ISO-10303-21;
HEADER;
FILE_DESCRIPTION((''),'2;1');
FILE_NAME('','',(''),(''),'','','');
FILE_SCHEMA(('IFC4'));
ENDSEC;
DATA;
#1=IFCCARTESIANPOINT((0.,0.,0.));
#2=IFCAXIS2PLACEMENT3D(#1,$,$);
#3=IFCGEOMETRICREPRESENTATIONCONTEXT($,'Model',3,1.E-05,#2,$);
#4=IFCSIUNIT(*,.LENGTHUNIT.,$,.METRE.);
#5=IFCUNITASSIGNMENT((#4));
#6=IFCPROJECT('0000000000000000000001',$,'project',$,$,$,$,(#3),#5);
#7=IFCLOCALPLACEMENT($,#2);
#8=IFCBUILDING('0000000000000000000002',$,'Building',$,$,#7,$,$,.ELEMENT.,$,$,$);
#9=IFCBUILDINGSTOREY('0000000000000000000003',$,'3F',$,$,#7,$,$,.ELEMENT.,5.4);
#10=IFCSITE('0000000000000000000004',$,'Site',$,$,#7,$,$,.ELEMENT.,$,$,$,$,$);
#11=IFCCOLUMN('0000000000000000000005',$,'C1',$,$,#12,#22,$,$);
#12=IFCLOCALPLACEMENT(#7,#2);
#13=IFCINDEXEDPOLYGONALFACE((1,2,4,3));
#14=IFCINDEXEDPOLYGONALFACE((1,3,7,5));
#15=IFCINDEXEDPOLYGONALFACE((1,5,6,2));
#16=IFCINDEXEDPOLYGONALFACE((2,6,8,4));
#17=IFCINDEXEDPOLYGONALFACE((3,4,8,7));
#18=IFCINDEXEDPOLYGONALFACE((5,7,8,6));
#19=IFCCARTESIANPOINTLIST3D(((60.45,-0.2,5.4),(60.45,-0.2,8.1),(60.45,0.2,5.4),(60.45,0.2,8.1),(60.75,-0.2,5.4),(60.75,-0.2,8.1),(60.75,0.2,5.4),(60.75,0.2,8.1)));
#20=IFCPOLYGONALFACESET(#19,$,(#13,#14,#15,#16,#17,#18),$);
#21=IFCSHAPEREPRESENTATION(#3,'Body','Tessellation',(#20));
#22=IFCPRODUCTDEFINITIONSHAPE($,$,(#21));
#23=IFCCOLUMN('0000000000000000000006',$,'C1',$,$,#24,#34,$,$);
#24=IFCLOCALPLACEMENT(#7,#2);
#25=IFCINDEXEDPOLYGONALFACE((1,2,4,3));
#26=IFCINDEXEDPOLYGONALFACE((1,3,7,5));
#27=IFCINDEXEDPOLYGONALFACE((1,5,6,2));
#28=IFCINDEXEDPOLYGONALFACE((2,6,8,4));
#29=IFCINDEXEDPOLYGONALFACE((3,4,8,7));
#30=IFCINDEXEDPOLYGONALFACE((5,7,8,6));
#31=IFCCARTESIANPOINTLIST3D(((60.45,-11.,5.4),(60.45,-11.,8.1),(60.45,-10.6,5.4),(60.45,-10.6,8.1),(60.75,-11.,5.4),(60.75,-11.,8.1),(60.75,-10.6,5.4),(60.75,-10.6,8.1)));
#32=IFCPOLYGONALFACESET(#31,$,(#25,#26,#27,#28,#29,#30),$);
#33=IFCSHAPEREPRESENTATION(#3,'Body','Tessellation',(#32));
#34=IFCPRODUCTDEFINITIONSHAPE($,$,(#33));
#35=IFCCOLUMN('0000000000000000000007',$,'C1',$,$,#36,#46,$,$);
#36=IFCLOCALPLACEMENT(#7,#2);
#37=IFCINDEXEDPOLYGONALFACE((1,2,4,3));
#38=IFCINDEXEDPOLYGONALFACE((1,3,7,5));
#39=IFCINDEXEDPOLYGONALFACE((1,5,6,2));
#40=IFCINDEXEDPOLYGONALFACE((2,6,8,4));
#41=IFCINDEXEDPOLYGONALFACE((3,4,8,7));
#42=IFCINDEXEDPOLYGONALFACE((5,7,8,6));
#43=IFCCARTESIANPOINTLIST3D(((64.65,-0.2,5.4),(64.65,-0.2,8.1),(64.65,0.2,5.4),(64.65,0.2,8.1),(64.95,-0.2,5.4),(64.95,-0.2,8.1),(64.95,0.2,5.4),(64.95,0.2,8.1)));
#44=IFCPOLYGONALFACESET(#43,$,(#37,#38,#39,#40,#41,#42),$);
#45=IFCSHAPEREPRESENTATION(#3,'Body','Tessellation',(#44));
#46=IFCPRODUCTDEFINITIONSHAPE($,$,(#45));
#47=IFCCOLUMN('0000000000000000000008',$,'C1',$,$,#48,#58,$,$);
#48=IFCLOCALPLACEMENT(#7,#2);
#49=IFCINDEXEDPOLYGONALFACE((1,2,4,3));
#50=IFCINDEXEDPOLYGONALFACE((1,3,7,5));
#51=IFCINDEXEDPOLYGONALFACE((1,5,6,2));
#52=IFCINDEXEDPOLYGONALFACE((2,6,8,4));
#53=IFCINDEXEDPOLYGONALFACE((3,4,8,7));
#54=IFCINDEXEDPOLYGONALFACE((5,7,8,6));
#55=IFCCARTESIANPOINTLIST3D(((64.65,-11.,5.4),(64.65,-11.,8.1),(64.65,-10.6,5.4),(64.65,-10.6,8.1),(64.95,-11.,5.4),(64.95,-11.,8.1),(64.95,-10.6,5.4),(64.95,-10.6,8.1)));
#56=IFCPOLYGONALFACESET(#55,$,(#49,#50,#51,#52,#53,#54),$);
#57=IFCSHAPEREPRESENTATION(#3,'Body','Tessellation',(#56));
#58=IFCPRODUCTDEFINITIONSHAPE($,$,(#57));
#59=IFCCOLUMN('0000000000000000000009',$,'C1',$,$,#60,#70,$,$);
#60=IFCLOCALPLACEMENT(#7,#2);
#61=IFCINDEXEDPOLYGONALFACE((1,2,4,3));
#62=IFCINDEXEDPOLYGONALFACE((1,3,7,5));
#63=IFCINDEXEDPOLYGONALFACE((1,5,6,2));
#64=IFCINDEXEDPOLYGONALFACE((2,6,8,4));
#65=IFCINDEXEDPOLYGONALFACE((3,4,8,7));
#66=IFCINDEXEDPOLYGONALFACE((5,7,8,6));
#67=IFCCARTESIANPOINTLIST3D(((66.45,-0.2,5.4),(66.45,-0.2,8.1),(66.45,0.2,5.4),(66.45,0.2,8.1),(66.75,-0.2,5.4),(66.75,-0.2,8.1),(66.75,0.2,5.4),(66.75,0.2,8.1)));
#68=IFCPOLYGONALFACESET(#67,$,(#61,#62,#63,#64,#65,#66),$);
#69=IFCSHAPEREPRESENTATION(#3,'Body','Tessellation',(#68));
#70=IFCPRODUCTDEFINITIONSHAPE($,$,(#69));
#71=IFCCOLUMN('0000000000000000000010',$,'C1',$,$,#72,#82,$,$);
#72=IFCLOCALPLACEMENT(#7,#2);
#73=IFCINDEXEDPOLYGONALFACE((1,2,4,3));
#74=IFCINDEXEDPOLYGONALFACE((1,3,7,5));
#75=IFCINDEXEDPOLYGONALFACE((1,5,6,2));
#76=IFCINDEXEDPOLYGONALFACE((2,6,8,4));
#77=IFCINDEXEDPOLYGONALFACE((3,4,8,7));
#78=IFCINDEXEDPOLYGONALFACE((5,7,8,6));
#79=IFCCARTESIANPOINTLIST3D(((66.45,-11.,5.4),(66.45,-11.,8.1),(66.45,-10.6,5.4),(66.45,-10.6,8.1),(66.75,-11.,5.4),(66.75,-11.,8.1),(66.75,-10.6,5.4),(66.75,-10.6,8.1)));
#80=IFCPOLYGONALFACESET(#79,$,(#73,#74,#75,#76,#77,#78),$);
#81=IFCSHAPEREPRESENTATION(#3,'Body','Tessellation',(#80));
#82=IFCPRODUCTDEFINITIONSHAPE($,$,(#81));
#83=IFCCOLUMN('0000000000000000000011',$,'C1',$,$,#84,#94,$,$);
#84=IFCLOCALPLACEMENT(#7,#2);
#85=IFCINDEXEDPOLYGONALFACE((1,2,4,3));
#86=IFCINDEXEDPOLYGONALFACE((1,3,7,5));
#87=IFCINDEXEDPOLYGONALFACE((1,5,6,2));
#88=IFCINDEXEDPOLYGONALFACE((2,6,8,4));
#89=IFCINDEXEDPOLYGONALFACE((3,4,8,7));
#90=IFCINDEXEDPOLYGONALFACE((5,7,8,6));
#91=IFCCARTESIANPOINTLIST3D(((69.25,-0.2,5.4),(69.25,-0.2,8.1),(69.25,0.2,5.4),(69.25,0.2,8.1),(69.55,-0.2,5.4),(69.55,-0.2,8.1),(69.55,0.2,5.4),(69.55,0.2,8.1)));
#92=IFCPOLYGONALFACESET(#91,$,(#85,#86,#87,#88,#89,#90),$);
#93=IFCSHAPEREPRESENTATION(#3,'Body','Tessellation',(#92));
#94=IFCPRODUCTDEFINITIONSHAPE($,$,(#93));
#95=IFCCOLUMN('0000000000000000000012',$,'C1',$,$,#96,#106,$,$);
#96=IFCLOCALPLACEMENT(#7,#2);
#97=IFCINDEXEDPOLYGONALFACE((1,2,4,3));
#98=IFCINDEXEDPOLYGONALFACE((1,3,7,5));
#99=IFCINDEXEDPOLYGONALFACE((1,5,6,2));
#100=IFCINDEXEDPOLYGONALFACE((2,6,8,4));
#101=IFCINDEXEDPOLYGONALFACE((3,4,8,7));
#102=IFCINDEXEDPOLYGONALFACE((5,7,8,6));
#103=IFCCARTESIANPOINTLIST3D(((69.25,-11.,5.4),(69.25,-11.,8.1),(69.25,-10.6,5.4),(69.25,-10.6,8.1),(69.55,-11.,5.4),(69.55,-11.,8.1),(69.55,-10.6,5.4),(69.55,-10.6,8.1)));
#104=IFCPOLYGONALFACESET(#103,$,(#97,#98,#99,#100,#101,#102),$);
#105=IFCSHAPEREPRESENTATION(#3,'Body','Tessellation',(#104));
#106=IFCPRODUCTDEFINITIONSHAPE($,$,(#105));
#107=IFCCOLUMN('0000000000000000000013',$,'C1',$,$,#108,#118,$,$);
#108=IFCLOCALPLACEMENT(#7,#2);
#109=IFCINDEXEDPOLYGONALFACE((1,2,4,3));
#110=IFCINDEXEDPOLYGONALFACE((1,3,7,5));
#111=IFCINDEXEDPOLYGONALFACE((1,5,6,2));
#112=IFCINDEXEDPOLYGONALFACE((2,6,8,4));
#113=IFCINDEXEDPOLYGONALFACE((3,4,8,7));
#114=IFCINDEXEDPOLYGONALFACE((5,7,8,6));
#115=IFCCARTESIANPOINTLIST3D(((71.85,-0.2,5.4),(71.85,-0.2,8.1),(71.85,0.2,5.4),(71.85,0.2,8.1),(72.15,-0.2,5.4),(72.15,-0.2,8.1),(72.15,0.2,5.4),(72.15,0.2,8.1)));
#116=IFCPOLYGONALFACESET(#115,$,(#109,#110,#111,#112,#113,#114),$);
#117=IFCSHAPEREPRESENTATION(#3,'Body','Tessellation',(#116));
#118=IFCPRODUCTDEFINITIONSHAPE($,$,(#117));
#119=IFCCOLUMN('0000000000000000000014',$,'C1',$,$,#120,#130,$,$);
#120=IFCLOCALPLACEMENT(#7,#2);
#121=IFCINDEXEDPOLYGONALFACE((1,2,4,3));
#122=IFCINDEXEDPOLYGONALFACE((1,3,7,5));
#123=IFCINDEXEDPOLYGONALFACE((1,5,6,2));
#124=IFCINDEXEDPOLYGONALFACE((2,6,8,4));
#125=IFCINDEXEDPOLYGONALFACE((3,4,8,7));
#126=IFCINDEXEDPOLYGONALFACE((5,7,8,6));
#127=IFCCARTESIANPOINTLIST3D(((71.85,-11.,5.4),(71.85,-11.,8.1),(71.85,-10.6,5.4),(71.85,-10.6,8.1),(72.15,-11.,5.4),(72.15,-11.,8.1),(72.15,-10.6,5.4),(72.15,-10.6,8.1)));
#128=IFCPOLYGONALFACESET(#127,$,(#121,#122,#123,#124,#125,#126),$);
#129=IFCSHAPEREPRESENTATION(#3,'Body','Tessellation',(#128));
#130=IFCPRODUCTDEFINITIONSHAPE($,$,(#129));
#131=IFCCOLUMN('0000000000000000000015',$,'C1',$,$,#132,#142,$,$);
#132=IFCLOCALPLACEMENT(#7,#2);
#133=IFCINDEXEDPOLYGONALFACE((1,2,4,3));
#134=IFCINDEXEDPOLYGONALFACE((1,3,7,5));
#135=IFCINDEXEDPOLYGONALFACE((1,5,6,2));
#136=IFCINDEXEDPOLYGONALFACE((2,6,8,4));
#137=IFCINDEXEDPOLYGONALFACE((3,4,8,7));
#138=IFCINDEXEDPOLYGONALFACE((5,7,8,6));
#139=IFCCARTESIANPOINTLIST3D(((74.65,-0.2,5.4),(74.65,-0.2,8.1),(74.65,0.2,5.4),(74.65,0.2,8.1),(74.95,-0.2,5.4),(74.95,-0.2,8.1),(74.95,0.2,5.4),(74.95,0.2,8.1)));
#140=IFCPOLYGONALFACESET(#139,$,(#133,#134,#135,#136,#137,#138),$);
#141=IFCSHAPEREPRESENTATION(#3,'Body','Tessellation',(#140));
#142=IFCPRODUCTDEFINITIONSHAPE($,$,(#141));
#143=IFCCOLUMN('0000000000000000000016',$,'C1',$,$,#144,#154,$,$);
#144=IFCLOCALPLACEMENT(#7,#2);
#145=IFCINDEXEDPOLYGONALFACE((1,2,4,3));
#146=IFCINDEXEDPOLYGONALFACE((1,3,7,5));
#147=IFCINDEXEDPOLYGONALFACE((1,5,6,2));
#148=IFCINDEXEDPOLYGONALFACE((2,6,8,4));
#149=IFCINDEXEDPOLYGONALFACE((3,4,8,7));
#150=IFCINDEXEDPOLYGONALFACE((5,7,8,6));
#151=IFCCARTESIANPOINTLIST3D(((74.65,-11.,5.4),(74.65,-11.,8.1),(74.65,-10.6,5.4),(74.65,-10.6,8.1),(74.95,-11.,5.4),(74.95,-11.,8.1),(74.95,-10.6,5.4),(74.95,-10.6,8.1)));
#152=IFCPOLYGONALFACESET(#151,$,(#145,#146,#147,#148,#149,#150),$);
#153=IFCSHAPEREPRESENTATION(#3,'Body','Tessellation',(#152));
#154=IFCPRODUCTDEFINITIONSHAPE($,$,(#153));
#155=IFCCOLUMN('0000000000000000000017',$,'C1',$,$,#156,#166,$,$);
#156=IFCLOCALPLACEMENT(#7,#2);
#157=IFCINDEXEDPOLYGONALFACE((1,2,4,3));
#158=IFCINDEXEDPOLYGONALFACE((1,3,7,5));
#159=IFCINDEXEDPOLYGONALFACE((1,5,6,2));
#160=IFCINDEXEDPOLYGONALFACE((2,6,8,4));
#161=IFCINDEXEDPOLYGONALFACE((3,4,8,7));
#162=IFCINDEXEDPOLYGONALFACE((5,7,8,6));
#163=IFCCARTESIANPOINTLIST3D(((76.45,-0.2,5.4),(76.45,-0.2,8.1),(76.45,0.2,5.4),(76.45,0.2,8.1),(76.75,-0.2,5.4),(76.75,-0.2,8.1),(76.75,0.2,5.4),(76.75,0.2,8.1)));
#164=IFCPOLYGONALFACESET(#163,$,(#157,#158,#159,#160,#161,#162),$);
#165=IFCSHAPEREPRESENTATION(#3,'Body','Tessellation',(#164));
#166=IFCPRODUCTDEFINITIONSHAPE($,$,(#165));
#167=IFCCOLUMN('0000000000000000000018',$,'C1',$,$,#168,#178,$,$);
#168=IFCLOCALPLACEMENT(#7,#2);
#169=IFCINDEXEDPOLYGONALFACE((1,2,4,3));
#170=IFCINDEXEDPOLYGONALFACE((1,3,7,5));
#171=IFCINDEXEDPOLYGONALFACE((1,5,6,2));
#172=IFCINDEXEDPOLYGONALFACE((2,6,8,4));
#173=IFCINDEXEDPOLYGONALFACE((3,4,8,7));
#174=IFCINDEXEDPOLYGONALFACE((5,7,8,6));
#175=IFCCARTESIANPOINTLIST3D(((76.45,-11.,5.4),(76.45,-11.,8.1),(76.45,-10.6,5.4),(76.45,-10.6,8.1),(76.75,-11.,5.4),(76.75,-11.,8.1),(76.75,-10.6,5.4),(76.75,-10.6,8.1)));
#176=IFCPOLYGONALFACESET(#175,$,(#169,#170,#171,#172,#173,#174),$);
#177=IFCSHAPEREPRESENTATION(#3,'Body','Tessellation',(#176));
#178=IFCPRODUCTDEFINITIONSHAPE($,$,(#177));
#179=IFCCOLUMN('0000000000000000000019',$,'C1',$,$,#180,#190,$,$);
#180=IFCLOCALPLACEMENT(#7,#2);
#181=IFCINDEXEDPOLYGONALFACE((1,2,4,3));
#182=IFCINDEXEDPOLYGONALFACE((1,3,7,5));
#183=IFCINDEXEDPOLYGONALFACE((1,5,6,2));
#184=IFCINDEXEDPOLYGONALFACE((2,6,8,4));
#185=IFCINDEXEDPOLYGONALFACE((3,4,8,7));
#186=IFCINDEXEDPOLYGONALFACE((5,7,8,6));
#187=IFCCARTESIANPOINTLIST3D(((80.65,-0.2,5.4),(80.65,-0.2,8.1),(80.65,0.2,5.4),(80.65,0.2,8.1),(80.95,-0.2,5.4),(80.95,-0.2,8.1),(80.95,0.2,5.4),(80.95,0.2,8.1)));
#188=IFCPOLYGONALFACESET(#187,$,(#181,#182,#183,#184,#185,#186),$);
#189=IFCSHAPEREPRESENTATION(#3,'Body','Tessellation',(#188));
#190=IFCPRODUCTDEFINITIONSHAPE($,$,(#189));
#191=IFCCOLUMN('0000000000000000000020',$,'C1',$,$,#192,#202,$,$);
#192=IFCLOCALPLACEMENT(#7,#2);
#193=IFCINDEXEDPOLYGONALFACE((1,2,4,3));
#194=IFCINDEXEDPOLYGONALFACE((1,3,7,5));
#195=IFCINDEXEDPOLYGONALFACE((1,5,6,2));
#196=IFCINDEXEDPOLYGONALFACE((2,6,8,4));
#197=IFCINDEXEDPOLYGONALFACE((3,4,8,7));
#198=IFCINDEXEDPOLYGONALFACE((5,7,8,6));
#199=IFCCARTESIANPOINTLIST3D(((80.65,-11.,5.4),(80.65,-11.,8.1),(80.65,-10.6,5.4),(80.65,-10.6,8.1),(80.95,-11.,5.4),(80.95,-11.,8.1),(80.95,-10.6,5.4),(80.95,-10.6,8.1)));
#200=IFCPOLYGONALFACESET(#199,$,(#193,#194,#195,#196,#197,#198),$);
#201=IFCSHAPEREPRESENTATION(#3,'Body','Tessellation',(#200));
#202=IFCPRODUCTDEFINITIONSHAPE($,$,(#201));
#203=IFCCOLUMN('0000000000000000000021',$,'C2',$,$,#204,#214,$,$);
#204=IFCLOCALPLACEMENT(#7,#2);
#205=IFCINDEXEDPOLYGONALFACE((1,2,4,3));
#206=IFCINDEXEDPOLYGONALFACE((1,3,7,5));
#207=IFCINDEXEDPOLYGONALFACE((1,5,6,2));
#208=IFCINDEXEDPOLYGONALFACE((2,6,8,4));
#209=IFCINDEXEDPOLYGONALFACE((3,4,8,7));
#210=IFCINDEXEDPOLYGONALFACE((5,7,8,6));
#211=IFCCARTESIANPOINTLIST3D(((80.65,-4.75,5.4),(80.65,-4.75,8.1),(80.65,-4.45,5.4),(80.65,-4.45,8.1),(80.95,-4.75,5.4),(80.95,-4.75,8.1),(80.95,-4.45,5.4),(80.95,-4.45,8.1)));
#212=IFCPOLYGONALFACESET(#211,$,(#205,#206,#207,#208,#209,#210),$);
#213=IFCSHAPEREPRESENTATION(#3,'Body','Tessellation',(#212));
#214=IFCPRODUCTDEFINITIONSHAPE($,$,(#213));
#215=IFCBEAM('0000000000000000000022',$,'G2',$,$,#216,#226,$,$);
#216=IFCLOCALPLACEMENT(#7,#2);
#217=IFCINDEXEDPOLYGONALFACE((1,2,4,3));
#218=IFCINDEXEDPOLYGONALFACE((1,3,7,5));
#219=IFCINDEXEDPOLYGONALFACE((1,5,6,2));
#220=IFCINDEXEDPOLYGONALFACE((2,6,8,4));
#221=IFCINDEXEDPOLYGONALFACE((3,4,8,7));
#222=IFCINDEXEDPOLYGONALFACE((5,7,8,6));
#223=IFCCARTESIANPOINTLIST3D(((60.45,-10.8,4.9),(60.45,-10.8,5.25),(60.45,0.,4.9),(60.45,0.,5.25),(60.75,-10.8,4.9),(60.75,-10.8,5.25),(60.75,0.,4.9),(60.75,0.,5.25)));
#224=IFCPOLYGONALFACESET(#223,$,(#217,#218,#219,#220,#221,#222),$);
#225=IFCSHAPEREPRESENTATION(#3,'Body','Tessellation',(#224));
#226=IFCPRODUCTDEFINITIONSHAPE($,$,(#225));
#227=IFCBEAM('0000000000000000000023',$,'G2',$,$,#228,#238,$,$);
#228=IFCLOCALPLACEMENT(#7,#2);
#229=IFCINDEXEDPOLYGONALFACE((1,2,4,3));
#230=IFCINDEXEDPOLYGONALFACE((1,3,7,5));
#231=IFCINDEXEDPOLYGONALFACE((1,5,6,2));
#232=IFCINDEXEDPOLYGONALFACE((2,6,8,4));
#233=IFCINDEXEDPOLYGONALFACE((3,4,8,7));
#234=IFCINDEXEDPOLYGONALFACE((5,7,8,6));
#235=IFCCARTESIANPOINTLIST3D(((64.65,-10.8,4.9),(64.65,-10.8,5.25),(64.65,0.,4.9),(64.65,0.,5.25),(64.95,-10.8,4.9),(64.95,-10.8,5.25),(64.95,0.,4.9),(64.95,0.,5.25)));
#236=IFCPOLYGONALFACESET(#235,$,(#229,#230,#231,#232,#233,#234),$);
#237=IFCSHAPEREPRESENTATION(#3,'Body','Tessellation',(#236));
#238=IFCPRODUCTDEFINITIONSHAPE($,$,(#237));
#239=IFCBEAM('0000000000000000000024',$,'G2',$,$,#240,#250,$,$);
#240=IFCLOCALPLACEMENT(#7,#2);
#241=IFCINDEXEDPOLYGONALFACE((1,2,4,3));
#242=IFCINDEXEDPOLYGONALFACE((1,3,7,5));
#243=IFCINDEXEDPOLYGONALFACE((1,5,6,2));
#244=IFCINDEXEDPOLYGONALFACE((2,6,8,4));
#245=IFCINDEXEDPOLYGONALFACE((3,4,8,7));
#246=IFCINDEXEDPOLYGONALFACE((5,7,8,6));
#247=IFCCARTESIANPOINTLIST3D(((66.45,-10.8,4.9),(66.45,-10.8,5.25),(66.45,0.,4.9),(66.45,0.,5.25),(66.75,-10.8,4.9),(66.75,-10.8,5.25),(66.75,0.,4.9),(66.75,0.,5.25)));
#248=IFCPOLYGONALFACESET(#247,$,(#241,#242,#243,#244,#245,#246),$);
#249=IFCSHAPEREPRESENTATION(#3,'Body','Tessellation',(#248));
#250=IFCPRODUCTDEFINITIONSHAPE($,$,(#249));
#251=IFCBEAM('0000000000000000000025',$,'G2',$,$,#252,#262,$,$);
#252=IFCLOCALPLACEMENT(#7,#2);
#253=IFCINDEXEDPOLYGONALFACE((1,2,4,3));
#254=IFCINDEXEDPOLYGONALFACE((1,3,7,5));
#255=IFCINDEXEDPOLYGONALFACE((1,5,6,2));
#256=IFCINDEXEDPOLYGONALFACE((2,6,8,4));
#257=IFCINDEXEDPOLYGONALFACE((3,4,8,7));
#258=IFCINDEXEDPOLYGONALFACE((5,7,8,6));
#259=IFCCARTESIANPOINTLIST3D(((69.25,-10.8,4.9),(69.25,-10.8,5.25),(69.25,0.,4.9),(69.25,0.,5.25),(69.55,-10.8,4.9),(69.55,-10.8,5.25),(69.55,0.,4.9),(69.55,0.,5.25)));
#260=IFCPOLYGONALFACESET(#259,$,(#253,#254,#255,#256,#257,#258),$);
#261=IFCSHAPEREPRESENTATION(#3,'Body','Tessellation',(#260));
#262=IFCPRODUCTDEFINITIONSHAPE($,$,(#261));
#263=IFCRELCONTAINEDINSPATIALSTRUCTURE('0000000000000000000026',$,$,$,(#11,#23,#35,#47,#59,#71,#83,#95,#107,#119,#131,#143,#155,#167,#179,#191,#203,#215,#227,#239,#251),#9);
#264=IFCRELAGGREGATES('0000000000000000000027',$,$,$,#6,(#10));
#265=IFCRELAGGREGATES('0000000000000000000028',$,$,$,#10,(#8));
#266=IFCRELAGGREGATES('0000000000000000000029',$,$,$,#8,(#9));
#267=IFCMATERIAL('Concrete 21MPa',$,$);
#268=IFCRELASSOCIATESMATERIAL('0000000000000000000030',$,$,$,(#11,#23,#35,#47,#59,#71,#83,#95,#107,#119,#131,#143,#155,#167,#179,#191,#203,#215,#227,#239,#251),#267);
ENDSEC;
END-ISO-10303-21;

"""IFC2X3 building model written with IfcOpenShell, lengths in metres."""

from ifc_helpers import new_model, si_unit, frame, origin, origin_2d, place, context, project, spatial, rectangle, extrude, material, element, save


model = new_model("IFC2X3")

# Units and contexts
model_context = context("Model", 3, precision=1e-05, world=origin())
ifc_project = project(units=[si_unit("LENGTHUNIT", "METRE")], contexts=[model_context])

# Site, building, storey
placement = place(None, origin())
site = spatial("IfcSite", under=ifc_project, at=placement, Name="Site", CompositionType="ELEMENT")
building = spatial("IfcBuilding", under=site, at=placement, Name="Building", CompositionType="ELEMENT")
storey = spatial("IfcBuildingStorey", under=building, at=placement, Name="3F", CompositionType="ELEMENT", Elevation=5.4)

# Columns
ifc_material = material(Name="Concrete 21MPa")
for number, where, name in (
    (1, (60.6, 0.0, 5.4), "C1"),
    (2, (60.6, -10.8, 5.4), "C1"),
    (3, (64.8, 0.0, 5.4), "C1"),
    (4, (64.8, -10.8, 5.4), "C1"),
    (5, (66.6, 0.0, 5.4), "C1"),
    (6, (66.6, -10.8, 5.4), "C1"),
    (7, (69.4, 0.0, 5.4), "C1"),
    (8, (69.4, -10.8, 5.4), "C1"),
    (9, (72.0, 0.0, 5.4), "C1"),
    (10, (72.0, -10.8, 5.4), "C1"),
    (11, (74.8, 0.0, 5.4), "C1"),
    (12, (74.8, -10.8, 5.4), "C1"),
    (13, (76.6, 0.0, 5.4), "C1"),
    (14, (76.6, -10.8, 5.4), "C1"),
    (15, (80.8, 0.0, 5.4), "C1"),
    (16, (80.8, -10.8, 5.4), "C1"),
):
    element("IfcColumn", number, at=place(None, frame(where)), inside=storey, material=ifc_material, Name=name, context=model_context, shape_type="SweptSolid", body=[
        extrude(rectangle(XDim=0.3, YDim=0.4, at=origin_2d()), origin(), (0.0, 0.0, 1.0), 2.7),
    ])
column_placement = place(None, frame((80.8, -4.6, 5.4)))
element("IfcColumn", 17, at=column_placement, inside=storey, material=ifc_material, Name="C2", context=model_context, shape_type="SweptSolid", body=[
    extrude(rectangle(XDim=0.3, YDim=0.3, at=origin_2d()), origin(), (0.0, 0.0, 1.0), 2.7),
])

# Beams
for number, where, name in (
    (18, (60.6, -5.4, 4.9), "G2"),
    (19, (64.8, -5.4, 4.9), "G2"),
    (20, (66.6, -5.4, 4.9), "G2"),
    (21, (69.4, -5.4, 4.9), "G2"),
):
    element("IfcBeam", number, at=place(None, frame(where)), inside=storey, material=ifc_material, Name=name, context=model_context, shape_type="SweptSolid", body=[
        extrude(rectangle(XDim=0.3, YDim=10.8, at=origin_2d()), origin(), (0.0, 0.0, 1.0), 0.35),
    ])

save(model, "model.ifc")
